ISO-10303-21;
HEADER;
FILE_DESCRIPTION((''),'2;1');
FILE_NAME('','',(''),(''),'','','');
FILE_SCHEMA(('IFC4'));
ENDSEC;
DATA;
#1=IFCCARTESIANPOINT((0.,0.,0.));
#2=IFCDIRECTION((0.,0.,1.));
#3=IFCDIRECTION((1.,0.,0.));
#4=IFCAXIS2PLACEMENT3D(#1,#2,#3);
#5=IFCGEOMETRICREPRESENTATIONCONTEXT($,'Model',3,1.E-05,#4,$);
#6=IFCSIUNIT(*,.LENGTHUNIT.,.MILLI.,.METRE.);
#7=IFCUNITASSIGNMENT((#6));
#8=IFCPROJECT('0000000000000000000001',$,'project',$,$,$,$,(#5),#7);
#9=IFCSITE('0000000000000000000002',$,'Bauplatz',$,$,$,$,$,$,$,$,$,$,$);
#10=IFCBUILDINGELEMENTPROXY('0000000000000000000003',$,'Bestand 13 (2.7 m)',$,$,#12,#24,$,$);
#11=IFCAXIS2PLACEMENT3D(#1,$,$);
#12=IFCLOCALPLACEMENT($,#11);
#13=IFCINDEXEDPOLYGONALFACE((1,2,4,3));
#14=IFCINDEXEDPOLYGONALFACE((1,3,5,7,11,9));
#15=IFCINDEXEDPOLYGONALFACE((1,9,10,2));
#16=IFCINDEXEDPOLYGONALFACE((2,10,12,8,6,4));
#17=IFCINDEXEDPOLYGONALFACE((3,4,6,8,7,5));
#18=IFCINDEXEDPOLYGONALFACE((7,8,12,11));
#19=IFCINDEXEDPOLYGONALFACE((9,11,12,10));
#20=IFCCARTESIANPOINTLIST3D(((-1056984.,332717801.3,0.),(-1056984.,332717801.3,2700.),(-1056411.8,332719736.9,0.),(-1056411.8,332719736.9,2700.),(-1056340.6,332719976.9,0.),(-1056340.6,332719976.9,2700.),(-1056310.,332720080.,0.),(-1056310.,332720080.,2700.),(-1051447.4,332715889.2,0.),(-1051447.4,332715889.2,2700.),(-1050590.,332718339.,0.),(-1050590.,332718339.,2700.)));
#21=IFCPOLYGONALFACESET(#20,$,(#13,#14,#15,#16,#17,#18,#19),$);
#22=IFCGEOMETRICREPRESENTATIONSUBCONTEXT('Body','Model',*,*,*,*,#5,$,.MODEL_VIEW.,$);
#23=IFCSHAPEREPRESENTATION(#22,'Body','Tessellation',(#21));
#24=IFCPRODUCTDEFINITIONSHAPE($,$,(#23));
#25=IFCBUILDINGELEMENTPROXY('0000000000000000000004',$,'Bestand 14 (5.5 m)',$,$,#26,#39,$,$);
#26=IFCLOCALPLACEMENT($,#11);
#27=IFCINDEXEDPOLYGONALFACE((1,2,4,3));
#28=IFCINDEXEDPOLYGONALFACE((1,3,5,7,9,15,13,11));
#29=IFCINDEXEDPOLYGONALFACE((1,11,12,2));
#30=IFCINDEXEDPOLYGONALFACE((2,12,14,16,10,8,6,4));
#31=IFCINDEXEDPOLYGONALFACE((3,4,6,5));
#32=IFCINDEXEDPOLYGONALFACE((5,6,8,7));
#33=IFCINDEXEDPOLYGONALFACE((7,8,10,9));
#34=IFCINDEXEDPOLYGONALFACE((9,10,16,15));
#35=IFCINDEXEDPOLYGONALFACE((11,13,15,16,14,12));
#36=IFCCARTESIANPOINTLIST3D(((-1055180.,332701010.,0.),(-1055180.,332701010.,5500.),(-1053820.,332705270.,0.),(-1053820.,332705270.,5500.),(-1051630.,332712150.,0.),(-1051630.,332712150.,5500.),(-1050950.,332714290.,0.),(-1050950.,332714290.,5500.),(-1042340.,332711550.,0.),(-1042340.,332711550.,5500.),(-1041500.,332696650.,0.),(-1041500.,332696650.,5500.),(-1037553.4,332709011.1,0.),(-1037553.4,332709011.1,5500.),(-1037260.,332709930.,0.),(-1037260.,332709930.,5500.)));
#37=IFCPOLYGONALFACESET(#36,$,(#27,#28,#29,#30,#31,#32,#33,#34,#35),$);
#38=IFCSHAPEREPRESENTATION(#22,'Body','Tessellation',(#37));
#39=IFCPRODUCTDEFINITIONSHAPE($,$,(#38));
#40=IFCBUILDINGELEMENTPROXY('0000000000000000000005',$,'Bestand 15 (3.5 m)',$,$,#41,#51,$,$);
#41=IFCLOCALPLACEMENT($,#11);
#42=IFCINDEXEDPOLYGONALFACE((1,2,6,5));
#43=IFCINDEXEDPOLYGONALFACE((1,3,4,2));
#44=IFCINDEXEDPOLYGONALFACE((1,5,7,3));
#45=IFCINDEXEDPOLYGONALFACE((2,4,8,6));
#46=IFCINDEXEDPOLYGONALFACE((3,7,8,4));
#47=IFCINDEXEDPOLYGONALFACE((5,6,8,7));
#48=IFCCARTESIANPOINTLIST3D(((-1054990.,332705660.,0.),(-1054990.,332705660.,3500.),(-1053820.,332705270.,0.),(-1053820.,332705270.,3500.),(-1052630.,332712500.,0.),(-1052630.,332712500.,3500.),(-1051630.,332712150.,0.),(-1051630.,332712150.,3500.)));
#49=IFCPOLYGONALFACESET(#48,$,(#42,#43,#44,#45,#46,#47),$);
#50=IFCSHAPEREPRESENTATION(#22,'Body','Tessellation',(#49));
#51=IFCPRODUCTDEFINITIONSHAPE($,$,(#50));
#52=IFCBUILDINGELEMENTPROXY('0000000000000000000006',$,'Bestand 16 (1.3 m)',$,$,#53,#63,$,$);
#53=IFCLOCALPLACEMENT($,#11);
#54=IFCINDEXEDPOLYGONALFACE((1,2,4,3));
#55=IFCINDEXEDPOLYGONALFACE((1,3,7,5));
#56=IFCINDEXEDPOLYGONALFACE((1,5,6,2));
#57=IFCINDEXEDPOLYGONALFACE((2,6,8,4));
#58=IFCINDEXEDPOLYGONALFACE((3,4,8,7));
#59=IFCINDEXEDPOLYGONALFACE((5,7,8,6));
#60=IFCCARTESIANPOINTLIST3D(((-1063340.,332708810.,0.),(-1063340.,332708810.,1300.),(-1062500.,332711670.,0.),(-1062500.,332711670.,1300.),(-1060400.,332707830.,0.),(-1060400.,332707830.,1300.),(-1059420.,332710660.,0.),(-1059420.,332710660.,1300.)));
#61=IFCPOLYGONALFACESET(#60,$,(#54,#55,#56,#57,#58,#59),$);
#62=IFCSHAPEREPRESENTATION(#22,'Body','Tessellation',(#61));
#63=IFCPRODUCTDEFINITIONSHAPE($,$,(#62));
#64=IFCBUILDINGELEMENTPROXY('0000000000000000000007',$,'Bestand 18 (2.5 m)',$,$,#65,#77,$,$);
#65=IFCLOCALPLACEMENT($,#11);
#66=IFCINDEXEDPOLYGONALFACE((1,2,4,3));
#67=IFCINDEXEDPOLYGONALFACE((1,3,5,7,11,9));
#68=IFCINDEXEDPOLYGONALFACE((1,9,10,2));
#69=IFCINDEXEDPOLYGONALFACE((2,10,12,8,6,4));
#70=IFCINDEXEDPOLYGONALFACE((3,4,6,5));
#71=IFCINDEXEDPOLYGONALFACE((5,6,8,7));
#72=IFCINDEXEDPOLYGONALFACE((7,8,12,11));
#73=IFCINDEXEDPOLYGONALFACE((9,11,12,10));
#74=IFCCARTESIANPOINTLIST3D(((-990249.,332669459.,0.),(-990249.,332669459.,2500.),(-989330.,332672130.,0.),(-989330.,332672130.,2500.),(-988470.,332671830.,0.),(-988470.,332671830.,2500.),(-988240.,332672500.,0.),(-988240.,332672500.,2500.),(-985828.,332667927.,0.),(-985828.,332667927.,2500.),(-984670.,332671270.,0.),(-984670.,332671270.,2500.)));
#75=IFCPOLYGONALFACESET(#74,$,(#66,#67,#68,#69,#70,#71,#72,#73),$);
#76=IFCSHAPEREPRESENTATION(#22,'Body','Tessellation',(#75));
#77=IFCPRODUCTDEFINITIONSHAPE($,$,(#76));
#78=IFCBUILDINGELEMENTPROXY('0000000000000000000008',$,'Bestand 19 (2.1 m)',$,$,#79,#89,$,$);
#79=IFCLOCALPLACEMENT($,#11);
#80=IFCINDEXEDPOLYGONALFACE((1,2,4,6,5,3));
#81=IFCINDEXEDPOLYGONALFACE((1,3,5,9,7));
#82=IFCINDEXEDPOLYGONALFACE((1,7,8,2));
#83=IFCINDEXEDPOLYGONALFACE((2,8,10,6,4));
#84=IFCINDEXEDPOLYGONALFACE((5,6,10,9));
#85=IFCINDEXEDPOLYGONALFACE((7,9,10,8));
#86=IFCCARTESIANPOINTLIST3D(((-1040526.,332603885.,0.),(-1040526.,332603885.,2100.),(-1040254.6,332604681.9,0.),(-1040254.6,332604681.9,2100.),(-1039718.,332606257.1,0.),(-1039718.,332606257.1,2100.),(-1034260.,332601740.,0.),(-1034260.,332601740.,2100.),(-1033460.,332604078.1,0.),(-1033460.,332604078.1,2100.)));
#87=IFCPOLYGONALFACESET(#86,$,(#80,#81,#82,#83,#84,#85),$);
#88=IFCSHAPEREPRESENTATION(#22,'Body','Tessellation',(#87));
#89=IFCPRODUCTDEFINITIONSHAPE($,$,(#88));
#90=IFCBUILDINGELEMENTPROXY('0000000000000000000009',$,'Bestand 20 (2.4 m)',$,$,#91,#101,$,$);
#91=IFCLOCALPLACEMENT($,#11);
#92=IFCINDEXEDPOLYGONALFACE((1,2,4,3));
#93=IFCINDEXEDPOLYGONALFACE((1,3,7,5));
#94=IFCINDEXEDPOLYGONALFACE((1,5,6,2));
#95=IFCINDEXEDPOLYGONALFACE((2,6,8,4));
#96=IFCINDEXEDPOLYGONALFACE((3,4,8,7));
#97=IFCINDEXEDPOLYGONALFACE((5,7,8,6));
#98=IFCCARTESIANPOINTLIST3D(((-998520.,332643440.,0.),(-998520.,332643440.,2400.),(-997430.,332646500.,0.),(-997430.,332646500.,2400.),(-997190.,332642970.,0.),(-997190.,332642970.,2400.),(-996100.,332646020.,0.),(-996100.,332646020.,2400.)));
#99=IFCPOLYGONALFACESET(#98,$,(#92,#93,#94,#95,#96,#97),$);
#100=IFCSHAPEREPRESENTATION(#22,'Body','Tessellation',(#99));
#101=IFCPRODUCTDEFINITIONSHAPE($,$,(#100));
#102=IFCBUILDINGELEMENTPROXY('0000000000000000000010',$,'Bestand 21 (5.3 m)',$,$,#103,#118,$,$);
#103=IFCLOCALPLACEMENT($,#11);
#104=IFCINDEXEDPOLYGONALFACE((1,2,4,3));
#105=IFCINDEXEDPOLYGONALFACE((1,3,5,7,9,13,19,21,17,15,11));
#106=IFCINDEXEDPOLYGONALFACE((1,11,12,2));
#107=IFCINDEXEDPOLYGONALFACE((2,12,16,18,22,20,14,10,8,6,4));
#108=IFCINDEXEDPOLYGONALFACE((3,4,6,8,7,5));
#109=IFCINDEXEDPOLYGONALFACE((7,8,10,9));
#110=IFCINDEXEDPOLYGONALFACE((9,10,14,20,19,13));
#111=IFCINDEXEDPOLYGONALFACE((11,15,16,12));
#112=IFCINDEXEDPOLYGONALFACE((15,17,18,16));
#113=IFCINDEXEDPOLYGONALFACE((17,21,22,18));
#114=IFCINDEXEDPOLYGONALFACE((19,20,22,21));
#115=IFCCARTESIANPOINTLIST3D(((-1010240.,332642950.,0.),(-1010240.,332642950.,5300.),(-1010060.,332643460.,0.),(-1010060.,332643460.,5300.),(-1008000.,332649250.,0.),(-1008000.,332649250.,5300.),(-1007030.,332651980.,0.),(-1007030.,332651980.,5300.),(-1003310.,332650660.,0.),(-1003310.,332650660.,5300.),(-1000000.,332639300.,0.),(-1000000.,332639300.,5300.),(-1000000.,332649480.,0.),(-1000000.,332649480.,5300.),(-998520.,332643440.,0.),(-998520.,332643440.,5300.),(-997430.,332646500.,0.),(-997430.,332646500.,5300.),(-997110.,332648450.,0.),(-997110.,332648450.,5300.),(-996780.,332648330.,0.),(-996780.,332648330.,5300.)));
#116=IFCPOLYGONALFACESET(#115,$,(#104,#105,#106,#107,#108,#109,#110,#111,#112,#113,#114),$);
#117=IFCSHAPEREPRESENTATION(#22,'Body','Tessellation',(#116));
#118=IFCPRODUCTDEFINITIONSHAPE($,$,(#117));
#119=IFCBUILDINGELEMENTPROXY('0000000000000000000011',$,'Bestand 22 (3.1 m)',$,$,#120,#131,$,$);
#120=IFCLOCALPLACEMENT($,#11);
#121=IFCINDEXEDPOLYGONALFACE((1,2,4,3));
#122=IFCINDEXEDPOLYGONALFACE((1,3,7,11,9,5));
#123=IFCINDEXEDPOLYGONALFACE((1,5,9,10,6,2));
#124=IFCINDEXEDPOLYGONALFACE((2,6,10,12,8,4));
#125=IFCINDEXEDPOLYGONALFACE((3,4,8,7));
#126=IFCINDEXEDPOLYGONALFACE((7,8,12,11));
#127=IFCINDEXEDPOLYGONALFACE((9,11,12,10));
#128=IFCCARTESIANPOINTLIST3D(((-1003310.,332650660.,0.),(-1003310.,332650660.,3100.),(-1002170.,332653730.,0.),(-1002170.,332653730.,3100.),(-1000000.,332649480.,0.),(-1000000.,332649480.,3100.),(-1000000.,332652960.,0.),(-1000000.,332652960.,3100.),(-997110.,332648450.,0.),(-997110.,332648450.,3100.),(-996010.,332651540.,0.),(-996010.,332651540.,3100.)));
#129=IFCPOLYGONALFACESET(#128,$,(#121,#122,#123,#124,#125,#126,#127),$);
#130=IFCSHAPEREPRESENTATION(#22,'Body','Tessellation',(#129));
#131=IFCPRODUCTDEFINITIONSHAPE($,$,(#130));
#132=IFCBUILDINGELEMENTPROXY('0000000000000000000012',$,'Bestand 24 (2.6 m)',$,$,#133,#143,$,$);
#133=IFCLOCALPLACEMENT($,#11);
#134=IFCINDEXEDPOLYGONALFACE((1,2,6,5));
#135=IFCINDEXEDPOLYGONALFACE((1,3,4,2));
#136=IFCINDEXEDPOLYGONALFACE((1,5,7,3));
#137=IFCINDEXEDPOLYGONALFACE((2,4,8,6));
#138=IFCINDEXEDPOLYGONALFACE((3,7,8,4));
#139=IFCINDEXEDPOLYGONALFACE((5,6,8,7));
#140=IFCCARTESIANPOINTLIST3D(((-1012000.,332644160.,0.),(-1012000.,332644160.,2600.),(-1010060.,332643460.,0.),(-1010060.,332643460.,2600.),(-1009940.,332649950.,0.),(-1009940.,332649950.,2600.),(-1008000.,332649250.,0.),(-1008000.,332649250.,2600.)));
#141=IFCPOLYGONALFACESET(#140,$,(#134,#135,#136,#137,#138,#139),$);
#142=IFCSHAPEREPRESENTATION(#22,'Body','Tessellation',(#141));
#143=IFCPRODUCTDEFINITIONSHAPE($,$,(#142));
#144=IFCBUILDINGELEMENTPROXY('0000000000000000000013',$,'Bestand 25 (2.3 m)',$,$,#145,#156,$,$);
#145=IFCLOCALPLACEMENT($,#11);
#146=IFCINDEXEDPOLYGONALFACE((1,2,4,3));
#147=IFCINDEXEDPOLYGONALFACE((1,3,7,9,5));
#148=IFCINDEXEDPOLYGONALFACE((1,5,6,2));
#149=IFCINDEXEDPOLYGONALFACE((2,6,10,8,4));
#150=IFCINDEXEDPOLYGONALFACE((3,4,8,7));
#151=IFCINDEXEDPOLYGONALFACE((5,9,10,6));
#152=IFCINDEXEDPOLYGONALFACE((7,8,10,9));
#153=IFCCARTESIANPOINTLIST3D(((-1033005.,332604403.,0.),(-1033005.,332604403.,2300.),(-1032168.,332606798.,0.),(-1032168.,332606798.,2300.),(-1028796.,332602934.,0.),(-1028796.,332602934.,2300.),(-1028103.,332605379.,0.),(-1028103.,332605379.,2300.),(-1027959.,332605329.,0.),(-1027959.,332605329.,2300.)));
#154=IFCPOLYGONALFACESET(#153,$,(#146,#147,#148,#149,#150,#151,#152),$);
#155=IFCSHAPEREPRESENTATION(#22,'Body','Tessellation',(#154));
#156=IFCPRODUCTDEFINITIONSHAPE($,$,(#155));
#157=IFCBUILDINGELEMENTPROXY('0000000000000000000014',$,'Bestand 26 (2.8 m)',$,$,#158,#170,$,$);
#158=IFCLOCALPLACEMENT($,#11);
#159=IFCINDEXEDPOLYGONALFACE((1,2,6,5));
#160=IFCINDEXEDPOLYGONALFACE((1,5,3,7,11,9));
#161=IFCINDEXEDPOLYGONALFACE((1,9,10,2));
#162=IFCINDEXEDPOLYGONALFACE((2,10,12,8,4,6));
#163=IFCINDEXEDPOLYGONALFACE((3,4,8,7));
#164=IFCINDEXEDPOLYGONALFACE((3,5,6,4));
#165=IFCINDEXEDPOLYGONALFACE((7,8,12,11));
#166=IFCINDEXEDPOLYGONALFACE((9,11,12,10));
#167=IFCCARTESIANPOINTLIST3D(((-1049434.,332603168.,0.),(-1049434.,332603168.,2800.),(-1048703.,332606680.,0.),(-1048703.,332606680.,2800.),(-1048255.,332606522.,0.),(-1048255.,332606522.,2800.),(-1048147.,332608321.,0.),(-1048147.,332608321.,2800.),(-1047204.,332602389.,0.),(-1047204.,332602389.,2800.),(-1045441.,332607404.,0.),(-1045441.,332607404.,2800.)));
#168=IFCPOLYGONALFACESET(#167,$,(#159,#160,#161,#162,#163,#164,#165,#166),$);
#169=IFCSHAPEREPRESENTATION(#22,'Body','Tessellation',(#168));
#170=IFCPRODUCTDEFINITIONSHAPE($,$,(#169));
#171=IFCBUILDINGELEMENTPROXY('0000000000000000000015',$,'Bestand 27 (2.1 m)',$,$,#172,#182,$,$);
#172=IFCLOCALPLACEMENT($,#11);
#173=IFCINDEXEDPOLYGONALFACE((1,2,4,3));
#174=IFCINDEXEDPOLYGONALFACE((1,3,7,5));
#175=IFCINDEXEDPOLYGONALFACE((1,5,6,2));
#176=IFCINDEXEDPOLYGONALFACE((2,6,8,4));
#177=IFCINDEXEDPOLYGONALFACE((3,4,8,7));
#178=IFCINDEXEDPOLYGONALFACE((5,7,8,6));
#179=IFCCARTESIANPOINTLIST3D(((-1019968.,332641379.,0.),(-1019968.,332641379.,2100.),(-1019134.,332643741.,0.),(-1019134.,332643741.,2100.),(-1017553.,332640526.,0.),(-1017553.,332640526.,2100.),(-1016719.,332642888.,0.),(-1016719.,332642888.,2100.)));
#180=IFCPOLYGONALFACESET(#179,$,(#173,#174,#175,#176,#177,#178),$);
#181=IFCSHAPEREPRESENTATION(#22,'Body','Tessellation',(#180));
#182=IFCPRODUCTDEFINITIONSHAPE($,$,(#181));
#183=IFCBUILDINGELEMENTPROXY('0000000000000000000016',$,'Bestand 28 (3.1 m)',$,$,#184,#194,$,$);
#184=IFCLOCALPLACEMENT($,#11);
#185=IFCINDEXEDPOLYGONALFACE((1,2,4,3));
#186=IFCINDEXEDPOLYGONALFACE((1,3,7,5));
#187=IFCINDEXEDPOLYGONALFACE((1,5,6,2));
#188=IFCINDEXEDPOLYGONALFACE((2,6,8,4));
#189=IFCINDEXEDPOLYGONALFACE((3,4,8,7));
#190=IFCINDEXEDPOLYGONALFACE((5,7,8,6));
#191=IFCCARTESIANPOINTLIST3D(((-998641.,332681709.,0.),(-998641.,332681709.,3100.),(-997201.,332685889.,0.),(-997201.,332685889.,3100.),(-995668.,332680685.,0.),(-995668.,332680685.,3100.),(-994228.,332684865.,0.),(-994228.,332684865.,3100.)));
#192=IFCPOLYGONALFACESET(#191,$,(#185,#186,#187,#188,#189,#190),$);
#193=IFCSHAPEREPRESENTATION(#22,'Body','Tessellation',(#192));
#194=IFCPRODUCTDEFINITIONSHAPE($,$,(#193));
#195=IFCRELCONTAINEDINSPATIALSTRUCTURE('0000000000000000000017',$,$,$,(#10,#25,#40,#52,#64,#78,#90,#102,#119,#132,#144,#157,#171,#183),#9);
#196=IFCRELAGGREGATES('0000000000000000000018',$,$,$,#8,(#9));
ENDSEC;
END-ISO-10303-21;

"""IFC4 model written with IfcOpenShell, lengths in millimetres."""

from ifc_helpers import new_model, si_unit, origin_with_axes, place, context, subcontext, project, spatial, indexed_curve, outline, extrude, element, save


model = new_model("IFC4")

# Units and contexts
model_context = context("Model", 3, precision=1e-05, world=origin_with_axes())
body_context = subcontext(model_context, "Body", "Model", "MODEL_VIEW")
ifc_project = project(units=[si_unit("LENGTHUNIT", "METRE", prefix="MILLI")], contexts=[model_context])

# Site
site = spatial("IfcSite", under=ifc_project, Name="Bauplatz")

# Building element proxies
proxy_1_placement = place(None, origin_with_axes())
element("IfcBuildingElementProxy", 1, at=proxy_1_placement, inside=site, Name="Bestand 13 (2.7 m)", context=body_context, shape_type="SweptSolid", body=[
    extrude(outline(indexed_curve([(-1050590.0, 332718339.0), (-1056310.0, 332720080.0), (-1056340.6, 332719976.9), (-1056411.8, 332719736.9), (-1056984.0, 332717801.3), (-1051447.4, 332715889.2)])), None, (0.0, 0.0, 1.0), 2700.0),
])
proxy_2_placement = place(None, origin_with_axes())
element("IfcBuildingElementProxy", 2, at=proxy_2_placement, inside=site, Name="Bestand 14 (5.5 m)", context=body_context, shape_type="SweptSolid", body=[
    extrude(outline(indexed_curve([(-1042340.0, 332711550.0), (-1050950.0, 332714290.0), (-1051630.0, 332712150.0), (-1053820.0, 332705270.0), (-1055180.0, 332701010.0), (-1041500.0, 332696650.0), (-1037553.4, 332709011.1), (-1037260.0, 332709930.0)])), None, (0.0, 0.0, 1.0), 5500.0),
])
proxy_3_placement = place(None, origin_with_axes())
element("IfcBuildingElementProxy", 3, at=proxy_3_placement, inside=site, Name="Bestand 15 (3.5 m)", context=body_context, shape_type="SweptSolid", body=[
    extrude(outline(indexed_curve([(-1051630.0, 332712150.0), (-1052630.0, 332712500.0), (-1054990.0, 332705660.0), (-1053820.0, 332705270.0)])), None, (0.0, 0.0, 1.0), 3500.0),
])
proxy_4_placement = place(None, origin_with_axes())
element("IfcBuildingElementProxy", 4, at=proxy_4_placement, inside=site, Name="Bestand 16 (1.3 m)", context=body_context, shape_type="SweptSolid", body=[
    extrude(outline(indexed_curve([(-1059420.0, 332710660.0), (-1062500.0, 332711670.0), (-1063340.0, 332708810.0), (-1060400.0, 332707830.0)])), None, (0.0, 0.0, 1.0), 1300.0),
])
proxy_5_placement = place(None, origin_with_axes())
element("IfcBuildingElementProxy", 5, at=proxy_5_placement, inside=site, Name="Bestand 18 (2.5 m)", context=body_context, shape_type="SweptSolid", body=[
    extrude(outline(indexed_curve([(-984670.0, 332671270.0), (-988240.0, 332672500.0), (-988470.0, 332671830.0), (-989330.0, 332672130.0), (-990249.0, 332669459.0), (-985828.0, 332667927.0)])), None, (0.0, 0.0, 1.0), 2500.0),
])
proxy_6_placement = place(None, origin_with_axes())
element("IfcBuildingElementProxy", 6, at=proxy_6_placement, inside=site, Name="Bestand 19 (2.1 m)", context=body_context, shape_type="SweptSolid", body=[
    extrude(outline(indexed_curve([(-1033460.0, 332604078.1), (-1039718.0, 332606257.1), (-1040254.6, 332604681.9), (-1040526.0, 332603885.0), (-1034260.0, 332601740.0)])), None, (0.0, 0.0, 1.0), 2100.0),
])
proxy_7_placement = place(None, origin_with_axes())
element("IfcBuildingElementProxy", 7, at=proxy_7_placement, inside=site, Name="Bestand 20 (2.4 m)", context=body_context, shape_type="SweptSolid", body=[
    extrude(outline(indexed_curve([(-996100.0, 332646020.0), (-997430.0, 332646500.0), (-998520.0, 332643440.0), (-997190.0, 332642970.0)])), None, (0.0, 0.0, 1.0), 2400.0),
])
proxy_8_placement = place(None, origin_with_axes())
element("IfcBuildingElementProxy", 8, at=proxy_8_placement, inside=site, Name="Bestand 21 (5.3 m)", context=body_context, shape_type="SweptSolid", body=[
    extrude(outline(indexed_curve([(-1003310.0, 332650660.0), (-1007030.0, 332651980.0), (-1008000.0, 332649250.0), (-1010060.0, 332643460.0), (-1010240.0, 332642950.0), (-1000000.0, 332639300.0), (-998520.0, 332643440.0), (-997430.0, 332646500.0), (-996780.0, 332648330.0), (-997110.0, 332648450.0), (-1000000.0, 332649480.0)])), None, (0.0, 0.0, 1.0), 5300.0),
])
proxy_9_placement = place(None, origin_with_axes())
element("IfcBuildingElementProxy", 9, at=proxy_9_placement, inside=site, Name="Bestand 22 (3.1 m)", context=body_context, shape_type="SweptSolid", body=[
    extrude(outline(indexed_curve([(-1000000.0, 332652960.0), (-1002170.0, 332653730.0), (-1003310.0, 332650660.0), (-1000000.0, 332649480.0), (-997110.0, 332648450.0), (-996010.0, 332651540.0)])), None, (0.0, 0.0, 1.0), 3100.0),
])
proxy_10_placement = place(None, origin_with_axes())
element("IfcBuildingElementProxy", 10, at=proxy_10_placement, inside=site, Name="Bestand 24 (2.6 m)", context=body_context, shape_type="SweptSolid", body=[
    extrude(outline(indexed_curve([(-1008000.0, 332649250.0), (-1009940.0, 332649950.0), (-1012000.0, 332644160.0), (-1010060.0, 332643460.0)])), None, (0.0, 0.0, 1.0), 2600.0),
])
proxy_11_placement = place(None, origin_with_axes())
element("IfcBuildingElementProxy", 11, at=proxy_11_placement, inside=site, Name="Bestand 25 (2.3 m)", context=body_context, shape_type="SweptSolid", body=[
    extrude(outline(indexed_curve([(-1028103.0, 332605379.0), (-1032168.0, 332606798.0), (-1033005.0, 332604403.0), (-1028796.0, 332602934.0), (-1027959.0, 332605329.0)])), None, (0.0, 0.0, 1.0), 2300.0),
])
proxy_12_placement = place(None, origin_with_axes())
element("IfcBuildingElementProxy", 12, at=proxy_12_placement, inside=site, Name="Bestand 26 (2.8 m)", context=body_context, shape_type="SweptSolid", body=[
    extrude(outline(indexed_curve([(-1045441.0, 332607404.0), (-1048147.0, 332608321.0), (-1048703.0, 332606680.0), (-1048255.0, 332606522.0), (-1049434.0, 332603168.0), (-1047204.0, 332602389.0)])), None, (0.0, 0.0, 1.0), 2800.0),
])
proxy_13_placement = place(None, origin_with_axes())
element("IfcBuildingElementProxy", 13, at=proxy_13_placement, inside=site, Name="Bestand 27 (2.1 m)", context=body_context, shape_type="SweptSolid", body=[
    extrude(outline(indexed_curve([(-1016719.0, 332642888.0), (-1019134.0, 332643741.0), (-1019968.0, 332641379.0), (-1017553.0, 332640526.0)])), None, (0.0, 0.0, 1.0), 2100.0),
])
proxy_14_placement = place(None, origin_with_axes())
element("IfcBuildingElementProxy", 14, at=proxy_14_placement, inside=site, Name="Bestand 28 (3.1 m)", context=body_context, shape_type="SweptSolid", body=[
    extrude(outline(indexed_curve([(-994228.0, 332684865.0), (-997201.0, 332685889.0), (-998641.0, 332681709.0), (-995668.0, 332680685.0)])), None, (0.0, 0.0, 1.0), 3100.0),
])

save(model, "model.ifc")
